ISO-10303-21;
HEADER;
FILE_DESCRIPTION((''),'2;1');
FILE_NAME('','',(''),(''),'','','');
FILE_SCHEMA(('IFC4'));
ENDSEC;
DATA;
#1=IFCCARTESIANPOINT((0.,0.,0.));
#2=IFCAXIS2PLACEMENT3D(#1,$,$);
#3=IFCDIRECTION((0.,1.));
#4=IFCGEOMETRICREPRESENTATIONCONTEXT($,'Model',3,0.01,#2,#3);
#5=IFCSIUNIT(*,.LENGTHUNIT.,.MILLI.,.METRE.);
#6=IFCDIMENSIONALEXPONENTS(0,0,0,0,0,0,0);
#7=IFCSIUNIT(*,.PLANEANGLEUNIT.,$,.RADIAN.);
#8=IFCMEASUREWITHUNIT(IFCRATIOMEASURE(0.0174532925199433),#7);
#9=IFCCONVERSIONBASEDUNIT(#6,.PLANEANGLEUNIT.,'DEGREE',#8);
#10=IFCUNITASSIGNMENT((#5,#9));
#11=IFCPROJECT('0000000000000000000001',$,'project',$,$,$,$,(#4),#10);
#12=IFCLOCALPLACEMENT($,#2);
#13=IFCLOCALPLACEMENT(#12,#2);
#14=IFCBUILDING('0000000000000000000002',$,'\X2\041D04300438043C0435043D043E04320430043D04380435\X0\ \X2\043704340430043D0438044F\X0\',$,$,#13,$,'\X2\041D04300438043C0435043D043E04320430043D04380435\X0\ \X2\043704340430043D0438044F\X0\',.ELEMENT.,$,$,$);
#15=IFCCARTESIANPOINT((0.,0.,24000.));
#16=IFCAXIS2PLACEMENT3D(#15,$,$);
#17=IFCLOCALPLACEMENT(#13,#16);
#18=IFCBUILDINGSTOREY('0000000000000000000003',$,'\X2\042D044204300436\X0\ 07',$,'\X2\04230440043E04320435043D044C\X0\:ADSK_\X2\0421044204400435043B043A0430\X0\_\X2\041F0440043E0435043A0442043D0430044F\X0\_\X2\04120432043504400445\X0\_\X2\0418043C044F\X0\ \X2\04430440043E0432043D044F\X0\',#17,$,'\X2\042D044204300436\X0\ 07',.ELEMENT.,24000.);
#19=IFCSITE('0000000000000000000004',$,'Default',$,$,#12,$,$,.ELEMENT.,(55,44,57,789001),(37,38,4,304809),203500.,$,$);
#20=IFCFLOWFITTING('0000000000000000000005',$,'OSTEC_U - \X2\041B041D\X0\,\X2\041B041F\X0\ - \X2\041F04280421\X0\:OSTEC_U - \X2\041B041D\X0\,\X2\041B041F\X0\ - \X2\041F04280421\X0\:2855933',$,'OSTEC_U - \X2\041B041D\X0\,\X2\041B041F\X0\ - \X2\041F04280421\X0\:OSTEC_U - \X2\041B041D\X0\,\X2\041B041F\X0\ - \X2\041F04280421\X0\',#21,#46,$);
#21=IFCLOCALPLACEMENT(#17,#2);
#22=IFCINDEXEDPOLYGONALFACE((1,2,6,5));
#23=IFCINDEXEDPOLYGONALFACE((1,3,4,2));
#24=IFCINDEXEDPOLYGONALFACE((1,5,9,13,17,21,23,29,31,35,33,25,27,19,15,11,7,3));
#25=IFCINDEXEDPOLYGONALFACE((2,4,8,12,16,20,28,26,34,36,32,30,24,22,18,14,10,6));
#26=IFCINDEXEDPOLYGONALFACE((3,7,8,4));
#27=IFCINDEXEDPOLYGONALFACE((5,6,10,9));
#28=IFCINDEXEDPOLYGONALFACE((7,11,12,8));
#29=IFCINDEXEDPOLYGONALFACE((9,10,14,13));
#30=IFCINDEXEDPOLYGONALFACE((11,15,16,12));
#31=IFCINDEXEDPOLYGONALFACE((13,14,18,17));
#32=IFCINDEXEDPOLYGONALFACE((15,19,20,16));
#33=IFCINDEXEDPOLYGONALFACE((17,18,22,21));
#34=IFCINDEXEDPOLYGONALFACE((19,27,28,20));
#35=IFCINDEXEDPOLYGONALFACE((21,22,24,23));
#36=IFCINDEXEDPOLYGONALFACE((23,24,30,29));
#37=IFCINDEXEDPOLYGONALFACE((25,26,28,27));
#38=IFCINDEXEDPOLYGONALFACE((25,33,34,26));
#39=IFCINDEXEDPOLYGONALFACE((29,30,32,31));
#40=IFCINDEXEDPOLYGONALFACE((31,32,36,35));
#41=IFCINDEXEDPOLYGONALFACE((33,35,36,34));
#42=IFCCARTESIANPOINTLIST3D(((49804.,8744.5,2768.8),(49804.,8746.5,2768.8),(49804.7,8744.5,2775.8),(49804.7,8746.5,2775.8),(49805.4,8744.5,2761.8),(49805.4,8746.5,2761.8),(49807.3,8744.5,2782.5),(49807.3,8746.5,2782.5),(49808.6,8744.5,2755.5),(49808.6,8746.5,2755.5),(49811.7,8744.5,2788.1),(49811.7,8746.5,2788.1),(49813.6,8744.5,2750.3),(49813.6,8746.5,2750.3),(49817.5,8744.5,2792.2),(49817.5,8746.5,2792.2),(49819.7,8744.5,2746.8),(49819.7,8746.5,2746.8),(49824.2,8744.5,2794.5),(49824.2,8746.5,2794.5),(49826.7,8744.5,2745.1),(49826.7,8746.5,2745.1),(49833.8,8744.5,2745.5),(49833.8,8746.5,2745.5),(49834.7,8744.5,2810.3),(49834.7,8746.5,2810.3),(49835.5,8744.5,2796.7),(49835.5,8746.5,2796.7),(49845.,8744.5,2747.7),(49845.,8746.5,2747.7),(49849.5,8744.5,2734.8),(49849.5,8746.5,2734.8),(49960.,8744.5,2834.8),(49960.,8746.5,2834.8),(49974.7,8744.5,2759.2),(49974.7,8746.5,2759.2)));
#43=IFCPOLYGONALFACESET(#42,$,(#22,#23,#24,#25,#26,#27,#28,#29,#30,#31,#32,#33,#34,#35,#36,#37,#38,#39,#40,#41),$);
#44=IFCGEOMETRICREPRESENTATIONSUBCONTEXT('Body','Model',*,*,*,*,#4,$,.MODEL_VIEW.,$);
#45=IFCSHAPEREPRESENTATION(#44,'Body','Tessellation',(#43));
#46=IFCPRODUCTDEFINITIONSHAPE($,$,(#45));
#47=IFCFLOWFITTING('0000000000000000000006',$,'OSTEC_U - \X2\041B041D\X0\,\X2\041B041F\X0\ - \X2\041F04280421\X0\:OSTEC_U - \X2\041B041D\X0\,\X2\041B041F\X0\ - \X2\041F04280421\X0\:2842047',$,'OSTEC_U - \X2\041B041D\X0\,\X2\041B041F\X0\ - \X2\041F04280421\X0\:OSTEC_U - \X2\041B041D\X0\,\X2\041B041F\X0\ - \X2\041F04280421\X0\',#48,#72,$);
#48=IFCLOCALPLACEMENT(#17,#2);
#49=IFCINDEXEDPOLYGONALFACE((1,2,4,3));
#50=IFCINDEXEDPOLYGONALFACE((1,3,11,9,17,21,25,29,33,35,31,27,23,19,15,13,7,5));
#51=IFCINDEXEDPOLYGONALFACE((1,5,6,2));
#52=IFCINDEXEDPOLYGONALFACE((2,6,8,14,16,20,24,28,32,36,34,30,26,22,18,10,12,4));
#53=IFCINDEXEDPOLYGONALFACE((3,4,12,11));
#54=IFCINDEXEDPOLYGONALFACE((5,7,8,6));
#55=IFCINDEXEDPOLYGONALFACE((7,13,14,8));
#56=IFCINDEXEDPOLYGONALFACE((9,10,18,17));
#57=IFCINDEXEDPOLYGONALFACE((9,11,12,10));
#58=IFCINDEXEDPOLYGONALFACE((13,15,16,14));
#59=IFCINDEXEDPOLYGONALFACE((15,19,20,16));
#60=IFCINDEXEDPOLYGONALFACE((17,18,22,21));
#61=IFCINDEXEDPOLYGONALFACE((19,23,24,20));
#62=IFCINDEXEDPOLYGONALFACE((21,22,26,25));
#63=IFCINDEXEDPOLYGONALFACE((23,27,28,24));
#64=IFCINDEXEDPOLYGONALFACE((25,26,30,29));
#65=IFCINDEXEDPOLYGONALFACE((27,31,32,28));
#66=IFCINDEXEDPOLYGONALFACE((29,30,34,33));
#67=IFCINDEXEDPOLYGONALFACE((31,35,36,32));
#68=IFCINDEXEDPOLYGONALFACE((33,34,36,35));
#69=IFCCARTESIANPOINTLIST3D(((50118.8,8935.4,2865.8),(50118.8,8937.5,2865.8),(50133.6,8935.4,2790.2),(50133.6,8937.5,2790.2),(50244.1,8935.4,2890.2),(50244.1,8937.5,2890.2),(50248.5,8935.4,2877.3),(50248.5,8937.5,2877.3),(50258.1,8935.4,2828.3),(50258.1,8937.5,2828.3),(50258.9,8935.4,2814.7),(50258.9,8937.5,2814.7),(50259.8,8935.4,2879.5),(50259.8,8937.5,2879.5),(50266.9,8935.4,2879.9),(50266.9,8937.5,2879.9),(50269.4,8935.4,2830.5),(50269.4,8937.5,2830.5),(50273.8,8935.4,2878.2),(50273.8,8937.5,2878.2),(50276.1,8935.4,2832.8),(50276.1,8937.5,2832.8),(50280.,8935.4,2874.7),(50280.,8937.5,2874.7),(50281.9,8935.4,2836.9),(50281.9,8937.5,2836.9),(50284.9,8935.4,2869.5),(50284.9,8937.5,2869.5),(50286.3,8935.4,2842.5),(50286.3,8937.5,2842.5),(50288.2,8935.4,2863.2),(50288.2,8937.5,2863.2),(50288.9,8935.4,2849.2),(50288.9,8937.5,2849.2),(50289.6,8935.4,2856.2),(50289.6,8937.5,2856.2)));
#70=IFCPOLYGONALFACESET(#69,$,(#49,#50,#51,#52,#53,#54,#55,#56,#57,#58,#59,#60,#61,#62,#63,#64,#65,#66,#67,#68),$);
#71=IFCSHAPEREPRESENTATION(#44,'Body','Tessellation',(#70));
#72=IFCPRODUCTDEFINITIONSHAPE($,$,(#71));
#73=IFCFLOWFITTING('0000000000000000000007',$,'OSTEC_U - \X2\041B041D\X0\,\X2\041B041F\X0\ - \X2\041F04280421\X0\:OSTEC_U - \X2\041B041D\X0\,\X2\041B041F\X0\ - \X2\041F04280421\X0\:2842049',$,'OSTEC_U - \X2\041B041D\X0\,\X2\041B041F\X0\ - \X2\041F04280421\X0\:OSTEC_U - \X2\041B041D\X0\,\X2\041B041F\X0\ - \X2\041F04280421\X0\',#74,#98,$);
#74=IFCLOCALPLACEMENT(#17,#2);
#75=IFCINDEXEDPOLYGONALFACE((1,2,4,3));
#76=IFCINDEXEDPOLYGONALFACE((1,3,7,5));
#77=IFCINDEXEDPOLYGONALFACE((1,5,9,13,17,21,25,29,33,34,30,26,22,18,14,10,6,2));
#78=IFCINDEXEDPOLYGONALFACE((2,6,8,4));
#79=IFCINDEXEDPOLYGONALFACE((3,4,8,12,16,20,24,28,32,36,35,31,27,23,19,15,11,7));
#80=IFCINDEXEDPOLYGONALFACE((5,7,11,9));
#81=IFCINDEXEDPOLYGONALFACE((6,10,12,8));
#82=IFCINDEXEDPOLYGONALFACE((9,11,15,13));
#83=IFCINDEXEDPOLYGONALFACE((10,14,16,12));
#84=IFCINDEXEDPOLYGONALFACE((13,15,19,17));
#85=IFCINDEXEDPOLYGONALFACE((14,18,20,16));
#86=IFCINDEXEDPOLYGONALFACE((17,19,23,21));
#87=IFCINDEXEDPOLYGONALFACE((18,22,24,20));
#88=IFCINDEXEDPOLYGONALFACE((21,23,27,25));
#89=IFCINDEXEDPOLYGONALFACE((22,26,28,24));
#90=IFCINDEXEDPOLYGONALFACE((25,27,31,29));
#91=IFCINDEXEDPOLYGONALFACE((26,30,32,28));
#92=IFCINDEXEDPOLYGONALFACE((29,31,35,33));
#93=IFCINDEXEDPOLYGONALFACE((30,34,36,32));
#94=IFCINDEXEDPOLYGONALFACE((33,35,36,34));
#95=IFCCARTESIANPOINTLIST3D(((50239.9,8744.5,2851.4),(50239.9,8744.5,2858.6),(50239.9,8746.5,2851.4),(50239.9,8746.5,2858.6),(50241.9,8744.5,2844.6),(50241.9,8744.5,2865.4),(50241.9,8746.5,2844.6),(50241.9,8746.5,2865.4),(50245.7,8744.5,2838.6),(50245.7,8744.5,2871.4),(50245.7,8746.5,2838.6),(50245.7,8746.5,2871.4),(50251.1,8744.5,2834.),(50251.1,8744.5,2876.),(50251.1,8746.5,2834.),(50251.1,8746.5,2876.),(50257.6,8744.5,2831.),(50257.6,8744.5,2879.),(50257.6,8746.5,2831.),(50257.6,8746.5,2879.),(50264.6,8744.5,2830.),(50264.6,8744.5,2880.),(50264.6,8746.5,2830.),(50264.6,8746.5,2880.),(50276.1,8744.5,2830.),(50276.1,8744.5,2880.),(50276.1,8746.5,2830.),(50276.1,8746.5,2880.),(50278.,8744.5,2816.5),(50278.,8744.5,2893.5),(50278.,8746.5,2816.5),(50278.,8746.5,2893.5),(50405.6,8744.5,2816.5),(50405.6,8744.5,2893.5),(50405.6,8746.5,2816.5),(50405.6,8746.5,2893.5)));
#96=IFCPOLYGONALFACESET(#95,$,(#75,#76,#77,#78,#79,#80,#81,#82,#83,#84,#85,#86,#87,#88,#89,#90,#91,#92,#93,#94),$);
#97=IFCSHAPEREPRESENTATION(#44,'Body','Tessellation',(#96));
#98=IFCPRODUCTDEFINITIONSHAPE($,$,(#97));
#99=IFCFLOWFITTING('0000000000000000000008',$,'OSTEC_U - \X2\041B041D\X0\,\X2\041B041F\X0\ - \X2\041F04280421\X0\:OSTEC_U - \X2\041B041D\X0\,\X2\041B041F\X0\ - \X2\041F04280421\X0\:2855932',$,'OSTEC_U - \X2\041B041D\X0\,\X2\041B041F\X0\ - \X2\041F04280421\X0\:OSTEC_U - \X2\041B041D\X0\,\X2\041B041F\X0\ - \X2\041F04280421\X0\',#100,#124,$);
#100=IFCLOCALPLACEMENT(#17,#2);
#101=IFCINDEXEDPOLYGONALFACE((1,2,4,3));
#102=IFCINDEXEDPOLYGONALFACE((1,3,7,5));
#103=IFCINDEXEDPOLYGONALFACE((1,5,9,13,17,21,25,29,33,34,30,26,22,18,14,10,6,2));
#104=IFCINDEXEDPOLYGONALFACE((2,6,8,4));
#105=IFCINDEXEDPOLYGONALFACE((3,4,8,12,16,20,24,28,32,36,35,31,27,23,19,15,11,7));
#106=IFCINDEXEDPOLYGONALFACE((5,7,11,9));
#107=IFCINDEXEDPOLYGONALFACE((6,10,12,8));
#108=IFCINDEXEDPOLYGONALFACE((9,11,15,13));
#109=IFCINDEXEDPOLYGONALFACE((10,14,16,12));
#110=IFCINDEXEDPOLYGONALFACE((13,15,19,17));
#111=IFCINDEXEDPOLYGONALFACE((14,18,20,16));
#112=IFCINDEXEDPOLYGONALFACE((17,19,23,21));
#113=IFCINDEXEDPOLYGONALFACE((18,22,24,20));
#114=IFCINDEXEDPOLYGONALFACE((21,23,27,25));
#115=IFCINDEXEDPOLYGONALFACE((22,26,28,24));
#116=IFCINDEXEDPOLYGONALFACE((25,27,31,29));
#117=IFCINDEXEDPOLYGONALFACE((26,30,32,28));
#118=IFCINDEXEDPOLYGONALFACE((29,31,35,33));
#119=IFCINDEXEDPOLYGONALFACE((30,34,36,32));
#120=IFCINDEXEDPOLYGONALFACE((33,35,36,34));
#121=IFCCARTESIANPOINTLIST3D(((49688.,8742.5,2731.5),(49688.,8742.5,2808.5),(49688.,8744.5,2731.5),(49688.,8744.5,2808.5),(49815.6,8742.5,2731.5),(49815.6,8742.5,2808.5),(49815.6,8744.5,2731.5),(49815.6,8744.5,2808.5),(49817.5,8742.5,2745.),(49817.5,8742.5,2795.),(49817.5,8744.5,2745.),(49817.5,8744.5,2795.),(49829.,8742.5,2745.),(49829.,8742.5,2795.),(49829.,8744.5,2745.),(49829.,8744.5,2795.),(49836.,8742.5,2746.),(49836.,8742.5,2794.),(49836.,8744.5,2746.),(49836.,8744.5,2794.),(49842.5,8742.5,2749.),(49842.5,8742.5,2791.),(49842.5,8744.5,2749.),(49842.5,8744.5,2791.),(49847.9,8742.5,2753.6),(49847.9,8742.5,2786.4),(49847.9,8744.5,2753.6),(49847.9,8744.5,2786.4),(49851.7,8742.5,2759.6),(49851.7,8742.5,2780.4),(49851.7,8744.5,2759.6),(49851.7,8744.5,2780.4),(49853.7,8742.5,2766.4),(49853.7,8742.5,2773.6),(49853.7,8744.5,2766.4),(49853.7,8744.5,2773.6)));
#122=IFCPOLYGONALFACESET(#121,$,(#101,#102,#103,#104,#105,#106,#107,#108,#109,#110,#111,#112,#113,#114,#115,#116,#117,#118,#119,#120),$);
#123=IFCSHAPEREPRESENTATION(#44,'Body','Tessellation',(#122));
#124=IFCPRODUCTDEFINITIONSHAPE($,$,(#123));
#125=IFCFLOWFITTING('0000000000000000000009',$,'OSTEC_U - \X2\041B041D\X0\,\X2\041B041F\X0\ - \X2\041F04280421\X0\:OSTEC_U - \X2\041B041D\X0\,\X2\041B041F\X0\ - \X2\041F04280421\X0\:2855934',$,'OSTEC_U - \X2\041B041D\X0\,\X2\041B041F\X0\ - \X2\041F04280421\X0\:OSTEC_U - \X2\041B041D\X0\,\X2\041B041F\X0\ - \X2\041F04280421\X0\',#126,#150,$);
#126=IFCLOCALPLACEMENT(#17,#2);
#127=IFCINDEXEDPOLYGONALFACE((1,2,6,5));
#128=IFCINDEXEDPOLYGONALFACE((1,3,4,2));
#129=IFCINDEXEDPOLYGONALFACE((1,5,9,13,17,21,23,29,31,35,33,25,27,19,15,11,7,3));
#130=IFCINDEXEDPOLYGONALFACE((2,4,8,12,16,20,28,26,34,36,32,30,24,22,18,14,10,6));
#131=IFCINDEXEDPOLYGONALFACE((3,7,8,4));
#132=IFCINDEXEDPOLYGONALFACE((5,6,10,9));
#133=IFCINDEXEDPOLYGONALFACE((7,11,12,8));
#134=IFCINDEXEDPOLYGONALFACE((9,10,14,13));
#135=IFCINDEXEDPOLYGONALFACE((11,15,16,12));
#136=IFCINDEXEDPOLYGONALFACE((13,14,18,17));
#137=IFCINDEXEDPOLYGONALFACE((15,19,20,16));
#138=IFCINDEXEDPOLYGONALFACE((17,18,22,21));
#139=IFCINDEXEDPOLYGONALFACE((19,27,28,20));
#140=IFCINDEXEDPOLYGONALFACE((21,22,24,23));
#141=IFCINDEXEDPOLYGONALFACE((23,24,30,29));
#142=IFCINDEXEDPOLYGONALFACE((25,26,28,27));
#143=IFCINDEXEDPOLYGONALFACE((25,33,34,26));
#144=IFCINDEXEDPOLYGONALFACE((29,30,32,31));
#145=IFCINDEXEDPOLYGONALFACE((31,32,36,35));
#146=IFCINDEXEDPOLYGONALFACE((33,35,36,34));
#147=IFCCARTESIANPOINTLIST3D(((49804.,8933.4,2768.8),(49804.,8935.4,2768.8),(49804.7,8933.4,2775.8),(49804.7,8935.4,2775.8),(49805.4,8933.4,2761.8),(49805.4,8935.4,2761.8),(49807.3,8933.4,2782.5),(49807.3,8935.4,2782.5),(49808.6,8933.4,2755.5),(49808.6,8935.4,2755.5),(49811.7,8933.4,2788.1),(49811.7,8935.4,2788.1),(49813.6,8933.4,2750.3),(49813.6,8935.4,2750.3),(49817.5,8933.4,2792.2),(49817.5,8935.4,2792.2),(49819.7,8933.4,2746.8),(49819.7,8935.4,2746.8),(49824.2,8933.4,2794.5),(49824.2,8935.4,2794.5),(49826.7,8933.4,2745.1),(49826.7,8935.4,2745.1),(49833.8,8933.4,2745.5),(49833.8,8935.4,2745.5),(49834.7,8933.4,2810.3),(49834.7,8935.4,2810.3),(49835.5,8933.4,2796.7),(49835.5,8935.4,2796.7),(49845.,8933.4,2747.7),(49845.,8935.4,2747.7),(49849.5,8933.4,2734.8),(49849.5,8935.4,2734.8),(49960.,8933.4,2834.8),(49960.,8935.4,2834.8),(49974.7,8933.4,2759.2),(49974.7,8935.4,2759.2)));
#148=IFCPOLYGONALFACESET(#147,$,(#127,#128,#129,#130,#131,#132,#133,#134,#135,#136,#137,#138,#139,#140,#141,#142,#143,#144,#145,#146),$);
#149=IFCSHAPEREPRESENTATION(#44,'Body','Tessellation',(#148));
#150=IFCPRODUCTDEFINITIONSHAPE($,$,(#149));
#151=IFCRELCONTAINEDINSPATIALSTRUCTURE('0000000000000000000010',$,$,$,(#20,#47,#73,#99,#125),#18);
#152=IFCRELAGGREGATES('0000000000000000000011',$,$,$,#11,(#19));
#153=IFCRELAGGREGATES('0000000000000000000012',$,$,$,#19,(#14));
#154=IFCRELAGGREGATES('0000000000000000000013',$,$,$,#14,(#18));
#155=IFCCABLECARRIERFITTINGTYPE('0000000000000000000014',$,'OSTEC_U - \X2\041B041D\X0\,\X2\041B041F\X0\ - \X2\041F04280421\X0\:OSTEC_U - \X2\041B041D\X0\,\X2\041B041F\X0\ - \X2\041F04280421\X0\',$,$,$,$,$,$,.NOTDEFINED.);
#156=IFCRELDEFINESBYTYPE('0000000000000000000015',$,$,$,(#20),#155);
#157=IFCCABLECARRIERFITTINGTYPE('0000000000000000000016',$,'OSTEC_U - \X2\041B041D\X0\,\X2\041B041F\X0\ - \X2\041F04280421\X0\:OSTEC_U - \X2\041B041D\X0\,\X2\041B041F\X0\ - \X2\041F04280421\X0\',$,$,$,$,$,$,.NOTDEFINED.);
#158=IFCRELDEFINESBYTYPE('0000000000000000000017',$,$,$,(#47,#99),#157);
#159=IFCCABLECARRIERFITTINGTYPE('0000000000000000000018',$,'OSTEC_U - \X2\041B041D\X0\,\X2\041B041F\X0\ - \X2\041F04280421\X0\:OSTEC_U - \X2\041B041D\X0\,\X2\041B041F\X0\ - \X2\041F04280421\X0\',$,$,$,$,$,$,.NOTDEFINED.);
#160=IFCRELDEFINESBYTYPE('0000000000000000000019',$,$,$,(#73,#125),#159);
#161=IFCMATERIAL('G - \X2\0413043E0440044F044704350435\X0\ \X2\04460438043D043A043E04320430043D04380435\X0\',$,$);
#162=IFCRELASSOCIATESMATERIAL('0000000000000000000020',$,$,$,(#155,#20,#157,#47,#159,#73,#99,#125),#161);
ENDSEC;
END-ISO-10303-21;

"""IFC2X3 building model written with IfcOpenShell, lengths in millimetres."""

from ifc_helpers import new_model, entity, si_unit, converted_unit, direction, frame, frame_2d, origin, place, context, subcontext, project, spatial, polyline, circle_curve, parameter, trimmed, segment, composite_curve, outline, extrude, source, transform, mapped, material, type_object, type_shapes, element, save


model = new_model("IFC2X3")

# Units and contexts
model_context = context("Model", 3, precision=0.01, world=origin(), true_north=direction((0.0, 1.0)))
body_context = subcontext(model_context, "Body", "Model", "MODEL_VIEW")
ifc_project = project(units=[si_unit("LENGTHUNIT", "METRE", prefix="MILLI"), converted_unit("PLANEANGLEUNIT", "DEGREE", entity("IfcRatioMeasure", 0.0174532925199433), si_unit("PLANEANGLEUNIT", "RADIAN"), dimensions=[0, 0, 0, 0, 0, 0, 0])], contexts=[model_context])

# Site, building, storey
site_placement = place(None, origin())
site = spatial("IfcSite", under=ifc_project, at=site_placement, Name="Default", CompositionType="ELEMENT", RefLatitude=(55, 44, 57, 789001), RefLongitude=(37, 38, 4, 304809), RefElevation=203500.0)
building_placement = place(site_placement, origin())
building = spatial("IfcBuilding", under=site, at=building_placement, Name="Наименование здания", LongName="Наименование здания", CompositionType="ELEMENT")
storey_placement = place(building_placement, frame((0.0, 0.0, 24000.0)))
storey = spatial("IfcBuildingStorey", under=building, at=storey_placement, Name="Этаж 07", ObjectType="Уровень:ADSK_Стрелка_Проектная_Вверх_Имя уровня", LongName="Этаж 07", CompositionType="ELEMENT", Elevation=24000.0)

# Flow fittings
ifc_material_1 = material(Name="G - Горячее цинкование")
shared_shape_1 = source(origin(), body_context, "Body", "SweptSolid", [
    extrude(outline(composite_curve([segment(trimmed(circle_curve(frame_2d((-41.5, 0.0), x_axis=(1.0, 0.0)), 25.0), [parameter(90.0)], [parameter(270.0)], True, "PARAMETER"), True, "CONTINUOUS"), segment(polyline([(-41.5, -25.0), (-30.0, -25.0)]), True, "CONTINUOUS"), segment(polyline([(-30.0, -25.0), (-28.1, -38.5)]), True, "CONTINUOUS"), segment(polyline([(-28.1, -38.5), (99.5, -38.5)]), True, "CONTINUOUS"), segment(polyline([(99.5, -38.5), (99.5, 38.5)]), True, "CONTINUOUS"), segment(polyline([(99.5, 38.5), (-28.1, 38.5)]), True, "CONTINUOUS"), segment(polyline([(-28.1, 38.5), (-30.0, 25.0)]), True, "CONTINUOUS"), segment(polyline([(-30.0, 25.0), (-41.5, 25.0)]), True, "CONTINUOUS")], self_intersect=False)), frame((41.5, 0.0, 0.0), z_axis=(0.0, 0.0, -1.0), x_axis=(1.0, 0.0, 0.0)), (0.0, 0.0, -1.0), 2.0),
])
cable_carrier_fitting_type_1 = type_object("IfcCableCarrierFittingType", Name="OSTEC_U - ЛН,ЛП - ПШС:OSTEC_U - ЛН,ЛП - ПШС", PredefinedType="NOTDEFINED", material=ifc_material_1)
type_shapes(cable_carrier_fitting_type_1, [shared_shape_1])
flow_fitting_1_placement = place(storey_placement, frame((49829.0, 8746.5, 2770.0), z_axis=(0.0, -1.0, 0.0), x_axis=(0.981491, 0.0, 0.191508)))
element("IfcFlowFitting", 1, at=flow_fitting_1_placement, inside=storey, type_object=cable_carrier_fitting_type_1, material=ifc_material_1, Name="OSTEC_U - ЛН,ЛП - ПШС:OSTEC_U - ЛН,ЛП - ПШС:2855933", ObjectType="OSTEC_U - ЛН,ЛП - ПШС:OSTEC_U - ЛН,ЛП - ПШС", context=body_context, shape_type="MappedRepresentation", body=[
    mapped(shared_shape_1, transform((0.0, 0.0, 0.0), scale=1.0)),
])
cable_carrier_fitting_type_2 = type_object("IfcCableCarrierFittingType", Name="OSTEC_U - ЛН,ЛП - ПШС:OSTEC_U - ЛН,ЛП - ПШС", PredefinedType="NOTDEFINED", material=ifc_material_1)
shared_shape_2 = source(origin(), body_context, "Body", "SweptSolid", [
    extrude(outline(composite_curve([segment(trimmed(circle_curve(frame_2d((-41.5, 0.0), x_axis=(1.0, 0.0)), 25.0), [parameter(90.0)], [parameter(270.0)], True, "PARAMETER"), True, "CONTINUOUS"), segment(polyline([(-41.5, -25.0), (-30.0, -25.0)]), True, "CONTINUOUS"), segment(polyline([(-30.0, -25.0), (-28.1, -38.5)]), True, "CONTINUOUS"), segment(polyline([(-28.1, -38.5), (99.5, -38.5)]), True, "CONTINUOUS"), segment(polyline([(99.5, -38.5), (99.5, 38.5)]), True, "CONTINUOUS"), segment(polyline([(99.5, 38.5), (-28.1, 38.5)]), True, "CONTINUOUS"), segment(polyline([(-28.1, 38.5), (-30.0, 25.0)]), True, "CONTINUOUS"), segment(polyline([(-30.0, 25.0), (-41.5, 25.0)]), True, "CONTINUOUS")], self_intersect=False)), frame((41.5, 0.0, 0.0)), (0.0, 0.0, 1.0), 2.0),
])
type_shapes(cable_carrier_fitting_type_2, [shared_shape_2])
flow_fitting_2_placement = place(storey_placement, frame((50264.6, 8935.5, 2855.0), z_axis=(0.0, 1.0, 0.0), x_axis=(-0.981491, 0.0, -0.191508)))
element("IfcFlowFitting", 2, at=flow_fitting_2_placement, inside=storey, type_object=cable_carrier_fitting_type_2, material=ifc_material_1, Name="OSTEC_U - ЛН,ЛП - ПШС:OSTEC_U - ЛН,ЛП - ПШС:2842047", ObjectType="OSTEC_U - ЛН,ЛП - ПШС:OSTEC_U - ЛН,ЛП - ПШС", context=body_context, shape_type="MappedRepresentation", body=[
    mapped(shared_shape_2, transform((0.0, 0.0, 0.0), scale=1.0)),
])
cable_carrier_fitting_type_3 = type_object("IfcCableCarrierFittingType", Name="OSTEC_U - ЛН,ЛП - ПШС:OSTEC_U - ЛН,ЛП - ПШС", PredefinedType="NOTDEFINED", material=ifc_material_1)
type_shapes(cable_carrier_fitting_type_3, [shared_shape_2])
flow_fitting_3_placement = place(storey_placement, frame((50264.6, 8746.5, 2855.0), z_axis=(0.0, -1.0, 0.0), x_axis=(1.0, 0.0, 0.0)))
element("IfcFlowFitting", 3, at=flow_fitting_3_placement, inside=storey, type_object=cable_carrier_fitting_type_3, material=ifc_material_1, Name="OSTEC_U - ЛН,ЛП - ПШС:OSTEC_U - ЛН,ЛП - ПШС:2842049", ObjectType="OSTEC_U - ЛН,ЛП - ПШС:OSTEC_U - ЛН,ЛП - ПШС", context=body_context, shape_type="MappedRepresentation", body=[
    mapped(shared_shape_2, transform((0.0, 0.0, 0.0), scale=1.0)),
])
flow_fitting_4_placement = place(storey_placement, frame((49829.0, 8744.5, 2770.0), z_axis=(0.0, -1.0, 0.0), x_axis=(-1.0, 0.0, 0.0)))
element("IfcFlowFitting", 4, at=flow_fitting_4_placement, inside=storey, type_object=cable_carrier_fitting_type_2, material=ifc_material_1, Name="OSTEC_U - ЛН,ЛП - ПШС:OSTEC_U - ЛН,ЛП - ПШС:2855932", ObjectType="OSTEC_U - ЛН,ЛП - ПШС:OSTEC_U - ЛН,ЛП - ПШС", context=body_context, shape_type="MappedRepresentation", body=[
    mapped(shared_shape_2, transform((0.0, 0.0, 0.0), scale=1.0)),
])
flow_fitting_5_placement = place(storey_placement, frame((49829.0, 8933.5, 2770.0), z_axis=(0.0, 1.0, 0.0), x_axis=(0.981491, 0.0, 0.191508)))
element("IfcFlowFitting", 5, at=flow_fitting_5_placement, inside=storey, type_object=cable_carrier_fitting_type_3, material=ifc_material_1, Name="OSTEC_U - ЛН,ЛП - ПШС:OSTEC_U - ЛН,ЛП - ПШС:2855934", ObjectType="OSTEC_U - ЛН,ЛП - ПШС:OSTEC_U - ЛН,ЛП - ПШС", context=body_context, shape_type="MappedRepresentation", body=[
    mapped(shared_shape_2, transform((0.0, 0.0, 0.0), scale=1.0)),
])

save(model, "model.ifc")
